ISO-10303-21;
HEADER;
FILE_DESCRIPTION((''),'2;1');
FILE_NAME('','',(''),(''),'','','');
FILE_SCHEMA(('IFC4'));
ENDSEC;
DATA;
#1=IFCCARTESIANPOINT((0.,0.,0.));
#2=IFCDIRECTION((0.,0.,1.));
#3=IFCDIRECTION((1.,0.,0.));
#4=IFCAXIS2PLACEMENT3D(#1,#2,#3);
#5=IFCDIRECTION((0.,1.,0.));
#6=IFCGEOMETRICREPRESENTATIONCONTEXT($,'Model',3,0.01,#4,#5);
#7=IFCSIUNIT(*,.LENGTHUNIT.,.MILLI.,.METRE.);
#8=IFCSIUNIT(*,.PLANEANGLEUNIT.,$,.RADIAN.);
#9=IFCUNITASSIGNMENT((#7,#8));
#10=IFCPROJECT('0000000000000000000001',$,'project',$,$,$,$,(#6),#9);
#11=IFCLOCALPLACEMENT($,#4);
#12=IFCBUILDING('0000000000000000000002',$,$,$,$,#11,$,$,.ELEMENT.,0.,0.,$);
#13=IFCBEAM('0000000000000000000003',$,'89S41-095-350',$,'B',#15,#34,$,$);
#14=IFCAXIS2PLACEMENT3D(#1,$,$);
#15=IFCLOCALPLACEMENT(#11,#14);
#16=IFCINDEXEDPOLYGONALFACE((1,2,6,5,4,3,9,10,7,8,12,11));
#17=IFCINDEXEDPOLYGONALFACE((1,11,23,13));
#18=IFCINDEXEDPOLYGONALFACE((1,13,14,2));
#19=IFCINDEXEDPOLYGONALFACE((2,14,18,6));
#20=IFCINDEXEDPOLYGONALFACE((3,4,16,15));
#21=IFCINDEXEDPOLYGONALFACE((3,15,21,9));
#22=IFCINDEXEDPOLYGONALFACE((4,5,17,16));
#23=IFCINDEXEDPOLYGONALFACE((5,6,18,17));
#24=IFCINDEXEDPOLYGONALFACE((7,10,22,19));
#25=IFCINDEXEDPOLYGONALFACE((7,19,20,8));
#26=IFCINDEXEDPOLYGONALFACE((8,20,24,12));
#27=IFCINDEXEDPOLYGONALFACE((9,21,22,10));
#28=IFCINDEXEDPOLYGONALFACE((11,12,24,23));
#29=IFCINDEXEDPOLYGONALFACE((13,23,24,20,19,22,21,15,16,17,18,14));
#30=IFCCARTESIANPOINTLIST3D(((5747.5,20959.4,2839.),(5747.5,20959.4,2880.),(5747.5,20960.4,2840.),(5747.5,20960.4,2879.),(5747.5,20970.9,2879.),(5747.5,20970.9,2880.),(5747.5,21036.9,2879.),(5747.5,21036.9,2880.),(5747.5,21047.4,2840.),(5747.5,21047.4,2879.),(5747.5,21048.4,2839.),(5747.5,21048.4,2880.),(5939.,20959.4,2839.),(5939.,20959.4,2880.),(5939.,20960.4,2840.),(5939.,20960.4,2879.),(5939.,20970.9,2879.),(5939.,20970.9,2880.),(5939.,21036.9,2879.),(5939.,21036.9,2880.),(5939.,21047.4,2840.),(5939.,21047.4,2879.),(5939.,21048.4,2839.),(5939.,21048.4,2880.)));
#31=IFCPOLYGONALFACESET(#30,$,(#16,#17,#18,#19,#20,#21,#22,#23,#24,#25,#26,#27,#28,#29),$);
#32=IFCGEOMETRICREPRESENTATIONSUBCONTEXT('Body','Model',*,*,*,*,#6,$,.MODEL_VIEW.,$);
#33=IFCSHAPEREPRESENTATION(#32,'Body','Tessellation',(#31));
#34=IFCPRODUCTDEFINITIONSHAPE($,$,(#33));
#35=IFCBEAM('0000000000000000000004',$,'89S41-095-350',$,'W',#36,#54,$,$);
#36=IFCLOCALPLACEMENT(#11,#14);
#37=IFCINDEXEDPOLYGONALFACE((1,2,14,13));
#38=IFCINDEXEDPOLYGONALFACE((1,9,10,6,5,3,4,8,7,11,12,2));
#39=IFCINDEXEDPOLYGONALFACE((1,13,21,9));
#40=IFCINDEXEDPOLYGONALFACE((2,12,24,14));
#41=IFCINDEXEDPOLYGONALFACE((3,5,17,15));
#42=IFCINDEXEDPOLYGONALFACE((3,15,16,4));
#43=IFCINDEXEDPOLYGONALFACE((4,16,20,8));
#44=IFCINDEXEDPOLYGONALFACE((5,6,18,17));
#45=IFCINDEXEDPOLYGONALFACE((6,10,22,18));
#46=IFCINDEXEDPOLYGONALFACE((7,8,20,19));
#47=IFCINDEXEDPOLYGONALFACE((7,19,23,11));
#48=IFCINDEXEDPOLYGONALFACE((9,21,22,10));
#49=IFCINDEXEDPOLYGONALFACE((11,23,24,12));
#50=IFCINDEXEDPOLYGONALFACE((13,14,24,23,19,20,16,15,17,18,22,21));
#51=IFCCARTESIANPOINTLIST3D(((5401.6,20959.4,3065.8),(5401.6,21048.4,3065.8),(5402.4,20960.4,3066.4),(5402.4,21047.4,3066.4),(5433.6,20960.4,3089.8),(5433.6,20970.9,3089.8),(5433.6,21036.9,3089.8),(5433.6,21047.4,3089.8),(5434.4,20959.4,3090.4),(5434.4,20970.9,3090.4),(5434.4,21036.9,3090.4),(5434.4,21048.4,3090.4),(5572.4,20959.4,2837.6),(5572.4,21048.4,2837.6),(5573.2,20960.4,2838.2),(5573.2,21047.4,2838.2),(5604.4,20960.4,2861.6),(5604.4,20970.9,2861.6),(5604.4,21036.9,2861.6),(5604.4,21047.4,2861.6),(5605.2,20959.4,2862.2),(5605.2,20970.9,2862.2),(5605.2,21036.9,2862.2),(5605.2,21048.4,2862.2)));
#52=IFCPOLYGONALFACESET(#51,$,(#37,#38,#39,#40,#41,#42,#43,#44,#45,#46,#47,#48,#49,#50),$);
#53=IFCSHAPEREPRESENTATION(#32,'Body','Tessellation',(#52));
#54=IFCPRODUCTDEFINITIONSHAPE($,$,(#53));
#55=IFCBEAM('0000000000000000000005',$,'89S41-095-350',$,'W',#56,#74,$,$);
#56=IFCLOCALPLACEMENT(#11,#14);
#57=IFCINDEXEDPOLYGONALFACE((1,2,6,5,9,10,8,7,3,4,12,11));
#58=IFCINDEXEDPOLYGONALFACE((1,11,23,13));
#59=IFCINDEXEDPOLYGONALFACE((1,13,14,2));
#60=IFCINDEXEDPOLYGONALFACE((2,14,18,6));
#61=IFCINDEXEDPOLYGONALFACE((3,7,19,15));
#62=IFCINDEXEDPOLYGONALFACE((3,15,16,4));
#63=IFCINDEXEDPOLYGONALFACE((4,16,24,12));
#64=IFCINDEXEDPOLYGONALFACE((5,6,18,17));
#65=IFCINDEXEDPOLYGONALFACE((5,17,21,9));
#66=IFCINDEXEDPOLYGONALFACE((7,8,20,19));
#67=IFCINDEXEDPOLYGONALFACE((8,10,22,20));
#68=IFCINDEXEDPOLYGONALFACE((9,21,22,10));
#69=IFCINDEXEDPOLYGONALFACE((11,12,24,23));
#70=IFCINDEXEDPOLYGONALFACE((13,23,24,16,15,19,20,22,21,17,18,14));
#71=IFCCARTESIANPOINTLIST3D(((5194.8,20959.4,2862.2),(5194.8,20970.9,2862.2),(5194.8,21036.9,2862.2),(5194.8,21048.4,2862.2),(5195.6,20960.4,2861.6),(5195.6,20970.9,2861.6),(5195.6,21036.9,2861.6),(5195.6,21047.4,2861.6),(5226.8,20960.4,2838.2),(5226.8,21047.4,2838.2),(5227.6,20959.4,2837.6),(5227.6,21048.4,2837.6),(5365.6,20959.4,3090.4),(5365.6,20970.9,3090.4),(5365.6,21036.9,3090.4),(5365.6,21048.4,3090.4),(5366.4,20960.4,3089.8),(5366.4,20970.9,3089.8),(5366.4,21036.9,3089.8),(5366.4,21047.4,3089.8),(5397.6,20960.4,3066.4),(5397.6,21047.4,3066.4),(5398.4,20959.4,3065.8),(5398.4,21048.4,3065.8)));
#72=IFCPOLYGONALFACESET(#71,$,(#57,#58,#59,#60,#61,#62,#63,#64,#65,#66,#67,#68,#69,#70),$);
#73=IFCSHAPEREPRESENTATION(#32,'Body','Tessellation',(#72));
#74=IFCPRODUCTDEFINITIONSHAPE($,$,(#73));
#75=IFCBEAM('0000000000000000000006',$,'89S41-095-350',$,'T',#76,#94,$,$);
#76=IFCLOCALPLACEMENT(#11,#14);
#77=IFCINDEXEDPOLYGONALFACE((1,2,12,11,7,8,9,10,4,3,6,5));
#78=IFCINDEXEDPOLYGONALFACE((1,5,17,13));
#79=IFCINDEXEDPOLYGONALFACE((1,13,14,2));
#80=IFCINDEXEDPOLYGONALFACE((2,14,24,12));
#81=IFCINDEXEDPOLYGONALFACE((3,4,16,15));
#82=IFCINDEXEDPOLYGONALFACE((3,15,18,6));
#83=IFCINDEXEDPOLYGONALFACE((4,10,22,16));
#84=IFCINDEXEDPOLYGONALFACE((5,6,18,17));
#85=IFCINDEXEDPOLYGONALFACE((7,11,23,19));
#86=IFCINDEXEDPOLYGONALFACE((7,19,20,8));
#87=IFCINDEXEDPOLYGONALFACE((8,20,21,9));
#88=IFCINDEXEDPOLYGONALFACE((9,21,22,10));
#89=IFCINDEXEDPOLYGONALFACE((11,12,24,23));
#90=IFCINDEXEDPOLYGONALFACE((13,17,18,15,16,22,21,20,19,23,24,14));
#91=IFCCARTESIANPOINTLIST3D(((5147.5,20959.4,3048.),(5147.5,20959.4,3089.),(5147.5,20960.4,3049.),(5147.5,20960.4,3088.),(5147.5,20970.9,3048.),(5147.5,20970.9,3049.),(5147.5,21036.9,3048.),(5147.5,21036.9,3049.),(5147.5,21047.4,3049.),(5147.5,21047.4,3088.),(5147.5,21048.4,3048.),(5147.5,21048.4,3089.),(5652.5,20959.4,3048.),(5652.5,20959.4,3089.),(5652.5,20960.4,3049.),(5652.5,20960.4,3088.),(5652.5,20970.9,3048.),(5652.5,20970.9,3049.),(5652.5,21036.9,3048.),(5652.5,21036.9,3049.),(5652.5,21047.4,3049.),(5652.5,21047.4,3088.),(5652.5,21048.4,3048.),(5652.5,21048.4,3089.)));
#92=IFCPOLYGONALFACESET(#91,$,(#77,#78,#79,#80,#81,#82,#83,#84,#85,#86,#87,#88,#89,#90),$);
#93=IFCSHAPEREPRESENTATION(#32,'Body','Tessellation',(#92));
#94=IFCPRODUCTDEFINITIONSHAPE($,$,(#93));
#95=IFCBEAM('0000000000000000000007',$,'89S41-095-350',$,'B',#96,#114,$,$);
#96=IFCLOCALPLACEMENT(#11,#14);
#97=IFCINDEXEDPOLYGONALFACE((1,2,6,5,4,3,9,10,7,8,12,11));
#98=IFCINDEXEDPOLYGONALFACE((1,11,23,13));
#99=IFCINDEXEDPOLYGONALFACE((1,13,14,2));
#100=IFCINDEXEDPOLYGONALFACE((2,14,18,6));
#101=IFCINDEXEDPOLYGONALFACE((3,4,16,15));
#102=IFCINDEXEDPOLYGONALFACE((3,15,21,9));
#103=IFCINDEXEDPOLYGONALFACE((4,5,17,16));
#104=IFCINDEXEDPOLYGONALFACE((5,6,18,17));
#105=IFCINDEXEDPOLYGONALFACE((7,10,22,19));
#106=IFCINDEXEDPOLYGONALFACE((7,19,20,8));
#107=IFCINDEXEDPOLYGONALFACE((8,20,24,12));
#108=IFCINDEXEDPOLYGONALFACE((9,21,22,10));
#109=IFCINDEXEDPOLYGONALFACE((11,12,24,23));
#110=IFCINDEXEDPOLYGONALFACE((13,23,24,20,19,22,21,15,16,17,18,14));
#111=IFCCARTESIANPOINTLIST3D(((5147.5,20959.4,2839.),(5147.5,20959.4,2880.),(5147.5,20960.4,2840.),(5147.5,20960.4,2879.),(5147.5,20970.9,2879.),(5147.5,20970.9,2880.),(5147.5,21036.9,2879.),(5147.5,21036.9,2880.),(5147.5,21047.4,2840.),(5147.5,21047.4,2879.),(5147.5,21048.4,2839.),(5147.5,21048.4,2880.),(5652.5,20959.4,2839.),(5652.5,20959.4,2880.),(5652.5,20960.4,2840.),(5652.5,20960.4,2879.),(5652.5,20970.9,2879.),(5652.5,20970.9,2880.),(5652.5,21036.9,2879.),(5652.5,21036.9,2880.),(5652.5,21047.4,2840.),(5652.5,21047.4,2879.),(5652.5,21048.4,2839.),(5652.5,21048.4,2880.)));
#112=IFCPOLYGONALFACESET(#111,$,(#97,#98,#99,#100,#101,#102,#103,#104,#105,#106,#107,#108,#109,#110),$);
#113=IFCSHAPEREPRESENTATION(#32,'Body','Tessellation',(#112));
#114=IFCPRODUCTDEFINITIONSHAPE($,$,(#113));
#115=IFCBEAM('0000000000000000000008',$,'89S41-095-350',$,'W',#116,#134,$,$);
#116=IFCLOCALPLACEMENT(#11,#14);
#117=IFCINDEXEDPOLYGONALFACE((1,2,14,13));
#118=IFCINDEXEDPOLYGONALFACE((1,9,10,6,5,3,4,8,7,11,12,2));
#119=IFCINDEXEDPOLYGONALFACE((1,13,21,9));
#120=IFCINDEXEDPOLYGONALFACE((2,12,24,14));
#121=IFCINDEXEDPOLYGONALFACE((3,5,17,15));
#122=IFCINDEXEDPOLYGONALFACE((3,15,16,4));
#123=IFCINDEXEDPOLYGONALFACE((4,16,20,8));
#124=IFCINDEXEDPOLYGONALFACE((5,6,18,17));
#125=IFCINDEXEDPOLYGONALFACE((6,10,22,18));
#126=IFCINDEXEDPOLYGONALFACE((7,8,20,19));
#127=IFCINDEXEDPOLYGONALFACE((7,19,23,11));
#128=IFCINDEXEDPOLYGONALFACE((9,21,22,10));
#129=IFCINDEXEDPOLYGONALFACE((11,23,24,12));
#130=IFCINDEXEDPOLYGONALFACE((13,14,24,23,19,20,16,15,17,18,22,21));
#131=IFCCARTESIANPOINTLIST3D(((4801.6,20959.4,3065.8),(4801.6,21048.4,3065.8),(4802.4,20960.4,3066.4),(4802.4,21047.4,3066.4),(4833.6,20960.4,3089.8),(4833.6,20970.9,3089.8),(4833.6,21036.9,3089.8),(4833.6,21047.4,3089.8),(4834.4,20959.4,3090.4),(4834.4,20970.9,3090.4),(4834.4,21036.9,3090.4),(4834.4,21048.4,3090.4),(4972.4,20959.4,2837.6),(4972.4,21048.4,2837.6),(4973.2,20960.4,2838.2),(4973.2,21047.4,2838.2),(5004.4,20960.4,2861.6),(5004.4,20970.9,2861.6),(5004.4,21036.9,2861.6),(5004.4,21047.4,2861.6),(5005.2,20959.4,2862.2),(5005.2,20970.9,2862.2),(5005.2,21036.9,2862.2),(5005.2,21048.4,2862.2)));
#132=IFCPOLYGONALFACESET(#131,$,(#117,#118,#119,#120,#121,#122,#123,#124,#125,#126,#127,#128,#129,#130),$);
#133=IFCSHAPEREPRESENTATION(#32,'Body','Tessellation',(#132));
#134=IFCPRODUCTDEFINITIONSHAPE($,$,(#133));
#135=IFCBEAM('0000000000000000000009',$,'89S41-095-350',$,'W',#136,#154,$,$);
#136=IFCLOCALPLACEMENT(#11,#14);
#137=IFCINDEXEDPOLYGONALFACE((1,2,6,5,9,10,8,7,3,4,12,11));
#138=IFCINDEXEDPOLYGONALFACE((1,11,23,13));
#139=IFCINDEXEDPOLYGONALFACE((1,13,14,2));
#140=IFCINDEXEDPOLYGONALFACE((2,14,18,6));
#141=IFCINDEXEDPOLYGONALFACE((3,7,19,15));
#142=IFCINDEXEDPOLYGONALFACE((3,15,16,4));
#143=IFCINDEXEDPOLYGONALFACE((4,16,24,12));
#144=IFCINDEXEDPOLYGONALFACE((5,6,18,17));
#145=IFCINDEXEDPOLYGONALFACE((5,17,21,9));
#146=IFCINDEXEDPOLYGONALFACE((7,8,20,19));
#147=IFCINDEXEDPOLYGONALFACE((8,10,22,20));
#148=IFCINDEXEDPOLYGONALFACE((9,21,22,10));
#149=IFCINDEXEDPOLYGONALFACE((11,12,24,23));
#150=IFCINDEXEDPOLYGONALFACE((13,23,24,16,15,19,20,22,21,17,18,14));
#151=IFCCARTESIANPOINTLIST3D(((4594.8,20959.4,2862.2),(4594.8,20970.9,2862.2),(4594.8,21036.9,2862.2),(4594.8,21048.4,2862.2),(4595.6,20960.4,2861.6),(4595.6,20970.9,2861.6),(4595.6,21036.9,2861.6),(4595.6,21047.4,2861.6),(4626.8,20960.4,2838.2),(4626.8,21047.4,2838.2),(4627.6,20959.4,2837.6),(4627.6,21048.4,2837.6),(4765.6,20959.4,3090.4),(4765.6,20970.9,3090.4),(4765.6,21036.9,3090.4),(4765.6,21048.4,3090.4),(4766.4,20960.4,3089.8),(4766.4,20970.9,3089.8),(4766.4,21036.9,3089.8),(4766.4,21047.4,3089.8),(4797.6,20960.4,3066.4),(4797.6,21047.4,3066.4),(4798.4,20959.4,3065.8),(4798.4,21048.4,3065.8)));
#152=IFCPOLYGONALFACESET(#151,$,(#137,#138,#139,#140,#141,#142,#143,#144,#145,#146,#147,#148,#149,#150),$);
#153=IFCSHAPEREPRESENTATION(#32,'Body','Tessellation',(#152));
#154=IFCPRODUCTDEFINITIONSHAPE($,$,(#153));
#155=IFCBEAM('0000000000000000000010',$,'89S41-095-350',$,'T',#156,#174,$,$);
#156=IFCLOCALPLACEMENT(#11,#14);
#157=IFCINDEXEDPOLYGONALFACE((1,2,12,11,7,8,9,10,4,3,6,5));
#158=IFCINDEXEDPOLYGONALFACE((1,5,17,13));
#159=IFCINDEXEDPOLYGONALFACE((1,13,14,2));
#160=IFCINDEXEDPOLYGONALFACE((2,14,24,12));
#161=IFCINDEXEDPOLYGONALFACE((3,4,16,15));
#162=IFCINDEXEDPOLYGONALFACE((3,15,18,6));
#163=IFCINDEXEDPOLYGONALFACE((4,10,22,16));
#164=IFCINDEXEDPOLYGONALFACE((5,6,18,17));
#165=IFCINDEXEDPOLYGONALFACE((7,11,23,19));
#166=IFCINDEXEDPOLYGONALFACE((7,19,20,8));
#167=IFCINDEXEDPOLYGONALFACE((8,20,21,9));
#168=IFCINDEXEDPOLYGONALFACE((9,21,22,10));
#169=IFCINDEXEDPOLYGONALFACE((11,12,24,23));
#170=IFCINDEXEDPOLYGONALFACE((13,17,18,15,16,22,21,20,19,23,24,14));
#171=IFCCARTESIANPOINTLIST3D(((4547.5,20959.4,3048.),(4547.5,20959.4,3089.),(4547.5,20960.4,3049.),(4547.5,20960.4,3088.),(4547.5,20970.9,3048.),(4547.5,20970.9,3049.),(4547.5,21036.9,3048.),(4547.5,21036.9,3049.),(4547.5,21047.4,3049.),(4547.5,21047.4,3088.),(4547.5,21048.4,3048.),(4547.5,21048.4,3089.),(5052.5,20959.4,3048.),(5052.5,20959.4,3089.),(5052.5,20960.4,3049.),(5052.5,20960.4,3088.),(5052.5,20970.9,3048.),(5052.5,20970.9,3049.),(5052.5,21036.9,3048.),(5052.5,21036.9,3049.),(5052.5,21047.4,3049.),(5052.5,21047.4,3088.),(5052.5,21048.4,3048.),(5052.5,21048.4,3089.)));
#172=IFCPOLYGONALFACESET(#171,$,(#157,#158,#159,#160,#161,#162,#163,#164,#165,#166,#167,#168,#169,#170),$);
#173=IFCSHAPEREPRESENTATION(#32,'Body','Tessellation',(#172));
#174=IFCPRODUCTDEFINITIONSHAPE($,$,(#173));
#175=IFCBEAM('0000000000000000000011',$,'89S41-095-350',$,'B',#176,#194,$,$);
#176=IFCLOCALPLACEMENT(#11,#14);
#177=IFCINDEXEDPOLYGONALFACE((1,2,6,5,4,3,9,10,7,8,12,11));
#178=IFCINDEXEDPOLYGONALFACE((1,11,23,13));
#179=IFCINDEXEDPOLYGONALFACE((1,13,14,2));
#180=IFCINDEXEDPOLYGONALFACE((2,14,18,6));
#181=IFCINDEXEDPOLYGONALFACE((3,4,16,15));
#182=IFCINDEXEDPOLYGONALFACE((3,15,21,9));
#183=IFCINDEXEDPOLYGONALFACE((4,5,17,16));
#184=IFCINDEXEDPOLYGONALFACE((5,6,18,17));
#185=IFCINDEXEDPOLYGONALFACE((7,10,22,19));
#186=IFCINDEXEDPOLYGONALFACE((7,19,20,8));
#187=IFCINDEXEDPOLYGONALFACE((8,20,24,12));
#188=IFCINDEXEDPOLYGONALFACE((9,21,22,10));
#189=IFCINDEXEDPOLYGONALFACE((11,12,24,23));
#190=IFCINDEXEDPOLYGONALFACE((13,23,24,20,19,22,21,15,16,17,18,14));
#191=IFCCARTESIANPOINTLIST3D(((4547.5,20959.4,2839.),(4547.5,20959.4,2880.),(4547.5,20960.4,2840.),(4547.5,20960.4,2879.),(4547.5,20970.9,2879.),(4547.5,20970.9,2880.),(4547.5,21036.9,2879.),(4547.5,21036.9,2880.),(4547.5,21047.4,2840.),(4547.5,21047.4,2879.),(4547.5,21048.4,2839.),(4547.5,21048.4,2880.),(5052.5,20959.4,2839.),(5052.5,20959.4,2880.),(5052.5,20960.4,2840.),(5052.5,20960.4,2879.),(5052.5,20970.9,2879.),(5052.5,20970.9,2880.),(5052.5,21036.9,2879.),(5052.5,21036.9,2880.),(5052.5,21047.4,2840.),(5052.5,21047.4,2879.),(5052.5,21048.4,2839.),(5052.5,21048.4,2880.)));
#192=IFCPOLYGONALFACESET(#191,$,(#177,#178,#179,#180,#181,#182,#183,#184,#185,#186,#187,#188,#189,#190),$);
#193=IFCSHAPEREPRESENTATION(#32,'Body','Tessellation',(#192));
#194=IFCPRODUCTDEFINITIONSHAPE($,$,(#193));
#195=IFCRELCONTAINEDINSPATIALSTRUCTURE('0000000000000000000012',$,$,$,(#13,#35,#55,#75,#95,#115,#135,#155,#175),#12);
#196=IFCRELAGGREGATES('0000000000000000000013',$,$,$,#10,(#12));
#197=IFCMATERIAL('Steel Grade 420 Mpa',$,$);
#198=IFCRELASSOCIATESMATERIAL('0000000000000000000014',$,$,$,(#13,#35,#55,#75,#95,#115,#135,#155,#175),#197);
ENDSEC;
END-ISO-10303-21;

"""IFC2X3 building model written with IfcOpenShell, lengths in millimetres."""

from ifc_helpers import new_model, si_unit, direction, frame, origin, origin_with_axes, origin_2d_with_axis, place, context, subcontext, project, spatial, c_section, extrude, source, transform, mapped, material, element, save


model = new_model("IFC2X3")

# Units and contexts
model_context = context("Model", 3, precision=0.01, world=origin_with_axes(), true_north=direction((0.0, 1.0, 0.0)))
body_context = subcontext(model_context, "Body", "Model", "MODEL_VIEW")
ifc_project = project(units=[si_unit("LENGTHUNIT", "METRE", prefix="MILLI"), si_unit("PLANEANGLEUNIT", "RADIAN")], contexts=[model_context])

# Building
building_placement = place(None, origin_with_axes())
building = spatial("IfcBuilding", under=ifc_project, at=building_placement, CompositionType="ELEMENT", ElevationOfRefHeight=0.0, ElevationOfTerrain=0.0)

# Shared definitions
ifc_material = material(Name="Steel Grade 420 Mpa")

# Beams
shared_shape_1 = source(origin(), body_context, "Body", "SweptSolid", [
    extrude(c_section(Depth=89.0, Width=41.0, WallThickness=1.0, Girth=11.5, at=origin_2d_with_axis()), origin_with_axes(), (0.0, 0.0, 1.0), 191.5),
])
beam_1_placement = place(None, frame((5747.5, 21003.9, 2859.5), z_axis=(1.0, 0.0, 0.0), x_axis=(0.0, 0.0, 1.0)))
element("IfcBeam", 1, at=beam_1_placement, inside=building, material=ifc_material, Name="89S41-095-350", ObjectType="B", context=body_context, shape_type="MappedRepresentation", body=[
    mapped(shared_shape_1, transform((0.0, 0.0, 0.0), scale=1.0)),
])
shared_shape_2 = source(origin(), body_context, "Body", "SweptSolid", [
    extrude(c_section(Depth=89.0, Width=41.0, WallThickness=1.0, Girth=11.5, at=origin_2d_with_axis()), origin_with_axes(), (0.0, 0.0, 1.0), 285.1),
])
beam_2_placement = place(None, frame((5418.0, 21003.9, 3078.1), z_axis=(0.599182, 0.0, -0.800613), x_axis=(0.800613, 0.0, 0.599182)))
element("IfcBeam", 2, at=beam_2_placement, inside=building, material=ifc_material, Name="89S41-095-350", ObjectType="W", context=body_context, shape_type="MappedRepresentation", body=[
    mapped(shared_shape_2, transform((0.0, 0.0, 0.0), scale=1.0)),
])
shared_shape_3 = source(origin(), body_context, "Body", "SweptSolid", [
    extrude(c_section(Depth=89.0, Width=41.0, WallThickness=1.0, Girth=11.5, at=origin_2d_with_axis()), origin_with_axes(), (0.0, 0.0, 1.0), 285.1),
])
beam_3_placement = place(None, frame((5211.2, 21003.9, 2849.9), z_axis=(0.599182, 0.0, 0.800613), x_axis=(-0.800613, 0.0, 0.599182)))
element("IfcBeam", 3, at=beam_3_placement, inside=building, material=ifc_material, Name="89S41-095-350", ObjectType="W", context=body_context, shape_type="MappedRepresentation", body=[
    mapped(shared_shape_3, transform((0.0, 0.0, 0.0), scale=1.0)),
])
shared_shape_4 = source(origin(), body_context, "Body", "SweptSolid", [
    extrude(c_section(Depth=89.0, Width=41.0, WallThickness=1.0, Girth=11.5, at=origin_2d_with_axis()), origin_with_axes(), (0.0, 0.0, 1.0), 505.0),
])
beam_4_placement = place(None, frame((5652.5, 21003.9, 3068.5), z_axis=(-1.0, 0.0, 0.0), x_axis=(0.0, 0.0, -1.0)))
element("IfcBeam", 4, at=beam_4_placement, inside=building, material=ifc_material, Name="89S41-095-350", ObjectType="T", context=body_context, shape_type="MappedRepresentation", body=[
    mapped(shared_shape_4, transform((0.0, 0.0, 0.0), scale=1.0)),
])
shared_shape_5 = source(origin(), body_context, "Body", "SweptSolid", [
    extrude(c_section(Depth=89.0, Width=41.0, WallThickness=1.0, Girth=11.5, at=origin_2d_with_axis()), origin_with_axes(), (0.0, 0.0, 1.0), 505.0),
])
beam_5_placement = place(None, frame((5147.5, 21003.9, 2859.5), z_axis=(1.0, 0.0, 0.0), x_axis=(0.0, 0.0, 1.0)))
element("IfcBeam", 5, at=beam_5_placement, inside=building, material=ifc_material, Name="89S41-095-350", ObjectType="B", context=body_context, shape_type="MappedRepresentation", body=[
    mapped(shared_shape_5, transform((0.0, 0.0, 0.0), scale=1.0)),
])
shared_shape_6 = source(origin(), body_context, "Body", "SweptSolid", [
    extrude(c_section(Depth=89.0, Width=41.0, WallThickness=1.0, Girth=11.5, at=origin_2d_with_axis()), origin_with_axes(), (0.0, 0.0, 1.0), 285.1),
])
beam_6_placement = place(None, frame((4818.0, 21003.9, 3078.1), z_axis=(0.599182, 0.0, -0.800613), x_axis=(0.800613, 0.0, 0.599182)))
element("IfcBeam", 6, at=beam_6_placement, inside=building, material=ifc_material, Name="89S41-095-350", ObjectType="W", context=body_context, shape_type="MappedRepresentation", body=[
    mapped(shared_shape_6, transform((0.0, 0.0, 0.0), scale=1.0)),
])
shared_shape_7 = source(origin(), body_context, "Body", "SweptSolid", [
    extrude(c_section(Depth=89.0, Width=41.0, WallThickness=1.0, Girth=11.5, at=origin_2d_with_axis()), origin_with_axes(), (0.0, 0.0, 1.0), 285.1),
])
beam_7_placement = place(None, frame((4611.2, 21003.9, 2849.9), z_axis=(0.599182, 0.0, 0.800613), x_axis=(-0.800613, 0.0, 0.599182)))
element("IfcBeam", 7, at=beam_7_placement, inside=building, material=ifc_material, Name="89S41-095-350", ObjectType="W", context=body_context, shape_type="MappedRepresentation", body=[
    mapped(shared_shape_7, transform((0.0, 0.0, 0.0), scale=1.0)),
])
shared_shape_8 = source(origin(), body_context, "Body", "SweptSolid", [
    extrude(c_section(Depth=89.0, Width=41.0, WallThickness=1.0, Girth=11.5, at=origin_2d_with_axis()), origin_with_axes(), (0.0, 0.0, 1.0), 505.0),
])
beam_8_placement = place(None, frame((5052.5, 21003.9, 3068.5), z_axis=(-1.0, 0.0, 0.0), x_axis=(0.0, 0.0, -1.0)))
element("IfcBeam", 8, at=beam_8_placement, inside=building, material=ifc_material, Name="89S41-095-350", ObjectType="T", context=body_context, shape_type="MappedRepresentation", body=[
    mapped(shared_shape_8, transform((0.0, 0.0, 0.0), scale=1.0)),
])
shared_shape_9 = source(origin(), body_context, "Body", "SweptSolid", [
    extrude(c_section(Depth=89.0, Width=41.0, WallThickness=1.0, Girth=11.5, at=origin_2d_with_axis()), origin_with_axes(), (0.0, 0.0, 1.0), 505.0),
])
beam_9_placement = place(None, frame((4547.5, 21003.9, 2859.5), z_axis=(1.0, 0.0, 0.0), x_axis=(0.0, 0.0, 1.0)))
element("IfcBeam", 9, at=beam_9_placement, inside=building, material=ifc_material, Name="89S41-095-350", ObjectType="B", context=body_context, shape_type="MappedRepresentation", body=[
    mapped(shared_shape_9, transform((0.0, 0.0, 0.0), scale=1.0)),
])

save(model, "model.ifc")
